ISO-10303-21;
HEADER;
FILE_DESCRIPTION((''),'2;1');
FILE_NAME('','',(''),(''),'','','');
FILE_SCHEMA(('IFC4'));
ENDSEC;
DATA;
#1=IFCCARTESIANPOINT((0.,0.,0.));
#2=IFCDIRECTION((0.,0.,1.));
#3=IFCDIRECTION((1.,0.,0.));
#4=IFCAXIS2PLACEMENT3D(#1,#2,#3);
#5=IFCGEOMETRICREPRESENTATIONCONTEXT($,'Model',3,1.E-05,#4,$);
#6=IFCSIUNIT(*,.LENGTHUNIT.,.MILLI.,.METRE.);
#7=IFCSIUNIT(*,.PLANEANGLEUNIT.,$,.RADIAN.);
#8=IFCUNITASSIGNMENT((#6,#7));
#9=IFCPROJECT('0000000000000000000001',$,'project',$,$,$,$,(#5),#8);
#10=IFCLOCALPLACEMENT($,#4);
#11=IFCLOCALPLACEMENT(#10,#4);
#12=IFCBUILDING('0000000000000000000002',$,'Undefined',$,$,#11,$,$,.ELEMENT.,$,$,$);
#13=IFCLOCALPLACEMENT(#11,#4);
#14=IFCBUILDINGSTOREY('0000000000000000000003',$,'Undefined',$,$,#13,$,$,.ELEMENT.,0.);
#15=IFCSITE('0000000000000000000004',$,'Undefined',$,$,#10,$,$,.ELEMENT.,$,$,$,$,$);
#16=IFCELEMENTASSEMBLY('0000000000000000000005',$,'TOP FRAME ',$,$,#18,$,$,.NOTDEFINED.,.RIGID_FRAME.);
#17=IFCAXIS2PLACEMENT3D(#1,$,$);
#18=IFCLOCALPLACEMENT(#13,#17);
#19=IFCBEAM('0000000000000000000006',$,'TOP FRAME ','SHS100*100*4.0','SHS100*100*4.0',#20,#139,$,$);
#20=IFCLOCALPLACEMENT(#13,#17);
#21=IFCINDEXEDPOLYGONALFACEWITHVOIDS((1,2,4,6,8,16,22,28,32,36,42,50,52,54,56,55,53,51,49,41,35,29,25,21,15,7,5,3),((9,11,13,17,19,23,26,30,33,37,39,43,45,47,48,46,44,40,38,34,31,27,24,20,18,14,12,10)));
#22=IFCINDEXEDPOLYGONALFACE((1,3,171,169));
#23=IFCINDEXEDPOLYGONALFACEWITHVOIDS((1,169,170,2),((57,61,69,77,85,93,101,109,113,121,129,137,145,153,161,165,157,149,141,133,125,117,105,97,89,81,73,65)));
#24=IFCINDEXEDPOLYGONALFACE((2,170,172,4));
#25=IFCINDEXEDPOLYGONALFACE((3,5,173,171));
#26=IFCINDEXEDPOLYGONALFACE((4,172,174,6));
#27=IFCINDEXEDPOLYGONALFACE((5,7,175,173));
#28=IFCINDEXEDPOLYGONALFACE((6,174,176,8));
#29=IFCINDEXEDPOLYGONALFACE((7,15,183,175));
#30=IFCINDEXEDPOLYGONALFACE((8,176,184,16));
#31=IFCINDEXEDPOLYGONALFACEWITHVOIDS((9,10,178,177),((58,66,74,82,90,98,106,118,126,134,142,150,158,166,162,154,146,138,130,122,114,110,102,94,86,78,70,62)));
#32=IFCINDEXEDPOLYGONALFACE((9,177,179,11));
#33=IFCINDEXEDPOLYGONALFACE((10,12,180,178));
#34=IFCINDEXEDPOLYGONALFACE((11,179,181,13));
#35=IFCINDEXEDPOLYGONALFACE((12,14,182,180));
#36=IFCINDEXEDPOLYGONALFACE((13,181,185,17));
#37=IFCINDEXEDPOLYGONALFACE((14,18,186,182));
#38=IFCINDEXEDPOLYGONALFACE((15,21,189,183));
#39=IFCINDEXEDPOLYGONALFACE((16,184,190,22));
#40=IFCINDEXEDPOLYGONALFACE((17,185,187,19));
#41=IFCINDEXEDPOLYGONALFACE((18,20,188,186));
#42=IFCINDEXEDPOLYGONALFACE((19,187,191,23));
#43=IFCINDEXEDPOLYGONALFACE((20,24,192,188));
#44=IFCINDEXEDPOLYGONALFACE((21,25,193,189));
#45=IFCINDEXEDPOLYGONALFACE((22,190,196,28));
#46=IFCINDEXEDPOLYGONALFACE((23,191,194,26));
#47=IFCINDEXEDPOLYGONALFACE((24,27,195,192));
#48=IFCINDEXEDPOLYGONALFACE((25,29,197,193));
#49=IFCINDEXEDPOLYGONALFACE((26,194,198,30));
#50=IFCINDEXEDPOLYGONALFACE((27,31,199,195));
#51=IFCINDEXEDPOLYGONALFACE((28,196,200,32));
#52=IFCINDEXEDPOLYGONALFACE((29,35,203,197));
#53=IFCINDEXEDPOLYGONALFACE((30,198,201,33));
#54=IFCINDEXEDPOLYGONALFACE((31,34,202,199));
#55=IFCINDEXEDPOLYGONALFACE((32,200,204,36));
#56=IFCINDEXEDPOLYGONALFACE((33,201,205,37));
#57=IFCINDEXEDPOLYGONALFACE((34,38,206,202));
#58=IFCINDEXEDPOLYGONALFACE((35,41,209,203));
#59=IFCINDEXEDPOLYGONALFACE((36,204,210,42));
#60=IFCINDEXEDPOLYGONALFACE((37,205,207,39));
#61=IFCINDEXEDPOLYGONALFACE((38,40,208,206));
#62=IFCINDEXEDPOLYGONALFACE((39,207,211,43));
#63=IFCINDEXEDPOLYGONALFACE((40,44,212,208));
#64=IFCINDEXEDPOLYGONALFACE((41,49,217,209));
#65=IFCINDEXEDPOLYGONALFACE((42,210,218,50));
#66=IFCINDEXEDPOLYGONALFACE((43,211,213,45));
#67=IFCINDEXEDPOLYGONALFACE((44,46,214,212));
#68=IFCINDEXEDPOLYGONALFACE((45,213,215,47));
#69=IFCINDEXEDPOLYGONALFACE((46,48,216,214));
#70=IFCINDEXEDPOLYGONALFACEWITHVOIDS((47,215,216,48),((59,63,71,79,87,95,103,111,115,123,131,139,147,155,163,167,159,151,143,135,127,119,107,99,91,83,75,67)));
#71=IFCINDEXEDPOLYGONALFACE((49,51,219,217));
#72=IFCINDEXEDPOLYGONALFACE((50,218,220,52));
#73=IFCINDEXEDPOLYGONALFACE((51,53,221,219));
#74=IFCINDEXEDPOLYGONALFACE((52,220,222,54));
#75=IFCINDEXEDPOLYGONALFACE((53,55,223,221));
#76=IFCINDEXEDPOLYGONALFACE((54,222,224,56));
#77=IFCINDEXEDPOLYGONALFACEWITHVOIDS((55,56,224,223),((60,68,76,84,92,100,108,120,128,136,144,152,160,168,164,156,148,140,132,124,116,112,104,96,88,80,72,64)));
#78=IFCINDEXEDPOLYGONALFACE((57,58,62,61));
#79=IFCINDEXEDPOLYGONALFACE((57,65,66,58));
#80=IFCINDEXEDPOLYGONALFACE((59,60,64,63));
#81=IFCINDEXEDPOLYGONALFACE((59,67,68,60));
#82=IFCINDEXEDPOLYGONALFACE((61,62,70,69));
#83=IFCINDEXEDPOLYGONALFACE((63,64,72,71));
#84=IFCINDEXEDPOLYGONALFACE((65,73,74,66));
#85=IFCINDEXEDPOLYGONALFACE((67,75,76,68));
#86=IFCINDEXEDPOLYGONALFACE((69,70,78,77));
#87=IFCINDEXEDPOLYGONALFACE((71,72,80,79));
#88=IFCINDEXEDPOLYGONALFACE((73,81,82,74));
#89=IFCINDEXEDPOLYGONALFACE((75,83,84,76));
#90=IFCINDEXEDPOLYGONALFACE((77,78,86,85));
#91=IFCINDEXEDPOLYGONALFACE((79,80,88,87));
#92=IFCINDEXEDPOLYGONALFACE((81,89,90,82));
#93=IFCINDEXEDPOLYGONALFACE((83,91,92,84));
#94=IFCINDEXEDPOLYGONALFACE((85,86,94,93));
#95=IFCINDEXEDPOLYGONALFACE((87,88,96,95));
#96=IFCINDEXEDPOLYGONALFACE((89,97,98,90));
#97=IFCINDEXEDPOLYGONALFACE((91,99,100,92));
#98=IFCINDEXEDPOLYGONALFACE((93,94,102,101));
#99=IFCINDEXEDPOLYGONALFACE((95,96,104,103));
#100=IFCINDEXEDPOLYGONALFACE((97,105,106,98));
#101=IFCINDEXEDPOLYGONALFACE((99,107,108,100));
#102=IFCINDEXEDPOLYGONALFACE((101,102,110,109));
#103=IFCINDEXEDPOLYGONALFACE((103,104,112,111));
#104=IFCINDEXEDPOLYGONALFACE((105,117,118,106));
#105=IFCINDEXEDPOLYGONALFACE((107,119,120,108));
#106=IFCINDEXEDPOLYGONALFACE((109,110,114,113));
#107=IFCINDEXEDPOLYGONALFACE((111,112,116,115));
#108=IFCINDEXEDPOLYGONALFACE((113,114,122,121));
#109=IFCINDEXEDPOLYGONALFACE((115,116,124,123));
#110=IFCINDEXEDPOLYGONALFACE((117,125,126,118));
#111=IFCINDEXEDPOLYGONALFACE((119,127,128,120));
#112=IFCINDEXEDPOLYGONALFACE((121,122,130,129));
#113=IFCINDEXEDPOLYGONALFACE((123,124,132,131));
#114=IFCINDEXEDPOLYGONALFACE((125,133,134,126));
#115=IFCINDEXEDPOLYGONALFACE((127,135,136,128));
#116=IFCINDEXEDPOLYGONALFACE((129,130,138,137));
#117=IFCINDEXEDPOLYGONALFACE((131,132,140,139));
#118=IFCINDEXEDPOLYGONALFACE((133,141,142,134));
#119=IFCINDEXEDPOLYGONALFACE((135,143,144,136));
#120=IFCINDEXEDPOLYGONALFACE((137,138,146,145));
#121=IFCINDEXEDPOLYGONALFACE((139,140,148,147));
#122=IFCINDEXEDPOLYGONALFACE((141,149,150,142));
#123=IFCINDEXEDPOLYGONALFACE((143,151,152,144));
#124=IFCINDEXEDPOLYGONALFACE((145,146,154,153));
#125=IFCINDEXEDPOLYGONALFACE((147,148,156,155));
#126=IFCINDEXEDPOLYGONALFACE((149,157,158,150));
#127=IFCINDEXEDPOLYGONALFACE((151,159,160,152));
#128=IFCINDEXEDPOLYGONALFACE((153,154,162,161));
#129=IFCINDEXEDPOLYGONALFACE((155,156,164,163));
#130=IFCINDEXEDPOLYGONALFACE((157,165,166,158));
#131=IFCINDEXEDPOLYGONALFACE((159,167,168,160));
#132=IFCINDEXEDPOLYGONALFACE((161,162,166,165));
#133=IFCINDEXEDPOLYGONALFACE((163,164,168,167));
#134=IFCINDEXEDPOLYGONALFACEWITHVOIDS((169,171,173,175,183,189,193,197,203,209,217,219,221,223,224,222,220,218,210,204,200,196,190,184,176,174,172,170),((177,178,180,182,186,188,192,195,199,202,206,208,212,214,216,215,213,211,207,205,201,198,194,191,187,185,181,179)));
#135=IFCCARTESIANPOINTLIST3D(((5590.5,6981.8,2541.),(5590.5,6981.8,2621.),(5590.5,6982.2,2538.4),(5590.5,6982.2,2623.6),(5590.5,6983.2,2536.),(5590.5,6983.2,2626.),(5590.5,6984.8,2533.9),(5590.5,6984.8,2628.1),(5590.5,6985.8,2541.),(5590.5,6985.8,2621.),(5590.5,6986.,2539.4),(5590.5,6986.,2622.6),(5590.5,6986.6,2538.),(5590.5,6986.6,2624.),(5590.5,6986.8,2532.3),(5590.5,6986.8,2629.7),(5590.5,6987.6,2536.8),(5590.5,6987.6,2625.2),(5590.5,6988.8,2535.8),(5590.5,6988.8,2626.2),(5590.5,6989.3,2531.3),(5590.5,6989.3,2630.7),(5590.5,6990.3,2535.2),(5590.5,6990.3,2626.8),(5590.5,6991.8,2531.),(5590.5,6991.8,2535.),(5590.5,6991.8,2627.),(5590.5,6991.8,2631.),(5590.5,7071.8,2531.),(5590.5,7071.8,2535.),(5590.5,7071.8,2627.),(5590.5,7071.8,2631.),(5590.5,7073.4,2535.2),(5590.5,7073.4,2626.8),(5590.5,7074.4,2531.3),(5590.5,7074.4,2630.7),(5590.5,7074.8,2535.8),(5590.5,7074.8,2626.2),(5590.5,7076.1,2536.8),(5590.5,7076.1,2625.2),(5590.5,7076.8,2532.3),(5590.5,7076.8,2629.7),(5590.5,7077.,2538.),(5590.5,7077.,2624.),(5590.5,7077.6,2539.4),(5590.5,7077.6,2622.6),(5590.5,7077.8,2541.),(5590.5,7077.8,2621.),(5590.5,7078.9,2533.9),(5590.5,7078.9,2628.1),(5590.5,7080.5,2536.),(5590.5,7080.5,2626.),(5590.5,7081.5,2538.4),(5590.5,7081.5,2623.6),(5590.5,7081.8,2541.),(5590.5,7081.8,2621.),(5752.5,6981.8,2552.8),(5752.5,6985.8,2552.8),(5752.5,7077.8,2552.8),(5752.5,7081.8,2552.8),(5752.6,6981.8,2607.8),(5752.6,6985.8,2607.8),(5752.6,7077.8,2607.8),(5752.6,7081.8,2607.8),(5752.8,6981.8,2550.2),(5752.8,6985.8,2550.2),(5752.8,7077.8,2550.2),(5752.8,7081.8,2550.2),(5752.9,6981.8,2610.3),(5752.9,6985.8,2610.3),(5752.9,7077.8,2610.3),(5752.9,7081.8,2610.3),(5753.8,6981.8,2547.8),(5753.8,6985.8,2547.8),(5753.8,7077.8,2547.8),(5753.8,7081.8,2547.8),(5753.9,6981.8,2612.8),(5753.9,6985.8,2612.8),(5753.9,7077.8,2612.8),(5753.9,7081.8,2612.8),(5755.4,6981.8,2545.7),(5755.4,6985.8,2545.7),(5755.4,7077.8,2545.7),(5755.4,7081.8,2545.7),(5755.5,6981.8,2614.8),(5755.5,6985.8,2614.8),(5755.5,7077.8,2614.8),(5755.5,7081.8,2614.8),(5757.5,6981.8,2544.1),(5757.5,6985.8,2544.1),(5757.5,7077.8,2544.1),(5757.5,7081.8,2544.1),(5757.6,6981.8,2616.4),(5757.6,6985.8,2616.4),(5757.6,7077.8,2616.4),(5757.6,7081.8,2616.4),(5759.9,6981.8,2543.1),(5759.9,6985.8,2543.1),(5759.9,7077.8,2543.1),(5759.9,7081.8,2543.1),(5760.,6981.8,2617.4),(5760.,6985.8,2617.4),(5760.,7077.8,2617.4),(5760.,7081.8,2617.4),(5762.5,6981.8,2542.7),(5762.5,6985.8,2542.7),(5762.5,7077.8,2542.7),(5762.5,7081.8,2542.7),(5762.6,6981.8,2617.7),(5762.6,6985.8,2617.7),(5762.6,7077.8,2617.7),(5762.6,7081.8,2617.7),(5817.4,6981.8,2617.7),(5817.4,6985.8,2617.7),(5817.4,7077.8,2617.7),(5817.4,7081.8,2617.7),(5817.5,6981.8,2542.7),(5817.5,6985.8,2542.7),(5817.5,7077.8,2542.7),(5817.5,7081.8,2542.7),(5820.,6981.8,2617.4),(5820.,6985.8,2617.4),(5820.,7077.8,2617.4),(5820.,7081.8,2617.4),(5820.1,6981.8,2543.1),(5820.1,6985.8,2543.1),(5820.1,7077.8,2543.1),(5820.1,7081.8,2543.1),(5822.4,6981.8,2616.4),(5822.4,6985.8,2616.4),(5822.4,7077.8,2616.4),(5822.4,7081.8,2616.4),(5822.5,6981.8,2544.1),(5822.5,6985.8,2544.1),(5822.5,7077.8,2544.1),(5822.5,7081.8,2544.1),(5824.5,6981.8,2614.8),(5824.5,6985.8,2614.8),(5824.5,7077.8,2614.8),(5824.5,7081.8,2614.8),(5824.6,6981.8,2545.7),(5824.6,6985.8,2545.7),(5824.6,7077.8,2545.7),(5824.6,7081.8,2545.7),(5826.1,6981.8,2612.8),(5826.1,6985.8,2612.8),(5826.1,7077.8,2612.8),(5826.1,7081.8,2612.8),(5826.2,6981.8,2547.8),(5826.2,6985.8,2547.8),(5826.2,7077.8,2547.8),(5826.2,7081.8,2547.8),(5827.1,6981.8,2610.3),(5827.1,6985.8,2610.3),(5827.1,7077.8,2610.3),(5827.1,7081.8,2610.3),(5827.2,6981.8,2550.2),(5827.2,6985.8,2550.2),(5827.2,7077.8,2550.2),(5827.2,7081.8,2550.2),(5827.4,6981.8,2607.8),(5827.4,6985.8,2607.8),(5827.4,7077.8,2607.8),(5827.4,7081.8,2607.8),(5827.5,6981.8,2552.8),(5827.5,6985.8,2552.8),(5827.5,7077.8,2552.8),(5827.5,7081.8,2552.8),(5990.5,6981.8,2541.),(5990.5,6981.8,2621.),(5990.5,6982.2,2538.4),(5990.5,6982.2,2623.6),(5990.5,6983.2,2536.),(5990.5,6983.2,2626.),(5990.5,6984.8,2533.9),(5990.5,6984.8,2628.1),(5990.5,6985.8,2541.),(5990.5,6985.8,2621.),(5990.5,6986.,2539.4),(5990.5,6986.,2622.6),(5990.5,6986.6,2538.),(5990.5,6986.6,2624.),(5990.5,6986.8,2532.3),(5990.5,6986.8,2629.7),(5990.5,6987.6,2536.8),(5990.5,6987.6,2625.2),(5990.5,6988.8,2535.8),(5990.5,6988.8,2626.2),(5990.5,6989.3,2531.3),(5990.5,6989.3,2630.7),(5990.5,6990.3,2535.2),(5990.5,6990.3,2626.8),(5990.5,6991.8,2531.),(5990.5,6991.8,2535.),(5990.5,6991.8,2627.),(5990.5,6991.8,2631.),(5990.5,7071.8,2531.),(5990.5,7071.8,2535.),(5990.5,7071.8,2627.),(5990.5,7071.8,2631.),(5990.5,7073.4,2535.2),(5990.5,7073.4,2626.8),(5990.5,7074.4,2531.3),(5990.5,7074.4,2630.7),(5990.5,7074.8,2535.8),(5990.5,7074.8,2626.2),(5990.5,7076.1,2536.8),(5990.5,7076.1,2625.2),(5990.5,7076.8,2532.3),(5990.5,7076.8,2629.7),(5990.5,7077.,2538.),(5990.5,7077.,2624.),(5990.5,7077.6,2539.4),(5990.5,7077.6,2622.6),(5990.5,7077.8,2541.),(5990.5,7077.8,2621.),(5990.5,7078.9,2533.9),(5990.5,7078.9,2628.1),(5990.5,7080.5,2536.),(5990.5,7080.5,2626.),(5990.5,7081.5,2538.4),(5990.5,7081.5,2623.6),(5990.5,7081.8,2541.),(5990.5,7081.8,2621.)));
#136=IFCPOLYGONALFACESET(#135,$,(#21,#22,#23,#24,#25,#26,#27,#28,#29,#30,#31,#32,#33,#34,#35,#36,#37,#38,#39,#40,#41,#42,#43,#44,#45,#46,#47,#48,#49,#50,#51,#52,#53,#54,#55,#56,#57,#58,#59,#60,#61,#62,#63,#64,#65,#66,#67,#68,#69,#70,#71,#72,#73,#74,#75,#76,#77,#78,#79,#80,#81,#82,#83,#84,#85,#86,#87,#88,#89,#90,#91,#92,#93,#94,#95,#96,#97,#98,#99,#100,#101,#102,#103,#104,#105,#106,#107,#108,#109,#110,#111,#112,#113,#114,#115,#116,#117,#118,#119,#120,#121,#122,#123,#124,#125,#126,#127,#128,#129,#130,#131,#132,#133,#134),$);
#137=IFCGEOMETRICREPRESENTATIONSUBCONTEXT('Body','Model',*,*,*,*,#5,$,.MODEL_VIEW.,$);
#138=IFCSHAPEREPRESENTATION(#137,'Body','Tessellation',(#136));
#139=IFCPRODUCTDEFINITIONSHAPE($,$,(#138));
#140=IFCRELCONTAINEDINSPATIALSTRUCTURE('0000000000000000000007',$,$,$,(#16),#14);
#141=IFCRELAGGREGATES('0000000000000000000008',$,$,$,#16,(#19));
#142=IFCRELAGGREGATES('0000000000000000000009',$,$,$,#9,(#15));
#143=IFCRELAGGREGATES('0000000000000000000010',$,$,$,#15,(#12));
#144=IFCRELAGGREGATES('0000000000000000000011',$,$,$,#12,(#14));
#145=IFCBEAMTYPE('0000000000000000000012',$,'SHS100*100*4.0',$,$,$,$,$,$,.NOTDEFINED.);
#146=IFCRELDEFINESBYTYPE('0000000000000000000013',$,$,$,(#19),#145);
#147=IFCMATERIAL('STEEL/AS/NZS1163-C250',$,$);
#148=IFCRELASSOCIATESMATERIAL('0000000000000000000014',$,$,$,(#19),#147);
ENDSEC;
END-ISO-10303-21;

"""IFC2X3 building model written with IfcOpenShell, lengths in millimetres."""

from ifc_helpers import new_model, si_unit, frame, frame_2d, origin_with_axes, origin_2d_with_axis, place, context, subcontext, project, spatial, polyline, circle_curve, parameter, trimmed, segment, composite_curve, hollow_rectangle, outline, extrude, boolean, material, type_object, element, aggregate, save


model = new_model("IFC2X3")

# Units and contexts
model_context = context("Model", 3, precision=1e-05, world=origin_with_axes())
body_context = subcontext(model_context, "Body", "Model", "MODEL_VIEW")
ifc_project = project(units=[si_unit("LENGTHUNIT", "METRE", prefix="MILLI"), si_unit("PLANEANGLEUNIT", "RADIAN")], contexts=[model_context])

# Site, building, storey
site_placement = place(None, origin_with_axes())
site = spatial("IfcSite", under=ifc_project, at=site_placement, Name="Undefined", CompositionType="ELEMENT")
building_placement = place(site_placement, origin_with_axes())
building = spatial("IfcBuilding", under=site, at=building_placement, Name="Undefined", CompositionType="ELEMENT")
storey_placement = place(building_placement, origin_with_axes())
storey = spatial("IfcBuildingStorey", under=building, at=storey_placement, Name="Undefined", CompositionType="ELEMENT", Elevation=0.0)

# Element assembly
ifc_material_1 = material(Name="STEEL/AS/NZS1163-C250")
assembly_1_placement = place(storey_placement, origin_with_axes())
assembly_1 = element("IfcElementAssembly", 1, at=assembly_1_placement, inside=storey, Name="TOP FRAME ", AssemblyPlace="NOTDEFINED", PredefinedType="RIGID_FRAME")

# Beam
beam_type_1 = type_object("IfcBeamType", Name="SHS100*100*4.0", PredefinedType="NOTDEFINED")
beam_1_placement = place(assembly_1_placement, frame((5990.5, 7031.8, 2581.0), z_axis=(0.0, 0.0, 1.0), x_axis=(-1.0, 0.0, 0.0)))
beam_1 = element("IfcBeam", 2, at=beam_1_placement, type_object=beam_type_1, material=ifc_material_1, Name="TOP FRAME ", Description="SHS100*100*4.0", ObjectType="SHS100*100*4.0", context=body_context, shape_type="CSG", body=[
    boolean("DIFFERENCE", extrude(hollow_rectangle(XDim=100.0, YDim=100.0, WallThickness=4.0, InnerFilletRadius=6.0, OuterFilletRadius=10.0, at=origin_2d_with_axis()), frame((400.0, 0.0, 0.0), z_axis=(-1.0, 0.0, 0.0), x_axis=(0.0, -1.0, 0.0)), (0.0, 0.0, 1.0), 400.0), extrude(outline(composite_curve([segment(trimmed(circle_curve(frame_2d((10.0, 10.0), x_axis=(-0.999999, -0.001138)), 10.0), [parameter(0.0)], [parameter(1.569658)], True, "PARAMETER"), True, "CONTINUOUS"), segment(polyline([(10.0, 0.0), (64.8, 0.0)]), True, "CONTINUOUS"), segment(trimmed(circle_curve(frame_2d((64.8, 10.0), x_axis=(0.0, -1.0)), 10.0), [parameter(0.0)], [parameter(1.569658)], True, "PARAMETER"), True, "CONTINUOUS"), segment(polyline([(74.8, 10.0), (74.9, 65.0)]), True, "CONTINUOUS"), segment(trimmed(circle_curve(frame_2d((64.9, 65.0), x_axis=(0.999999, -0.001138)), 10.0), [parameter(0.0)], [parameter(1.571934)], True, "PARAMETER"), True, "CONTINUOUS"), segment(polyline([(64.9, 75.0), (9.9, 75.0)]), True, "CONTINUOUS"), segment(trimmed(circle_curve(frame_2d((9.9, 65.0), x_axis=(0.0, 1.0)), 10.0), [parameter(0.0)], [parameter(1.571934)], True, "PARAMETER"), True, "CONTINUOUS"), segment(polyline([(-0.1, 65.0), (0.0, 10.0)]), True, "CONTINUOUS")], self_intersect=True)), frame((237.9, 53.0, 36.7), z_axis=(-0.000004, -1.0, 0.0), x_axis=(-1.0, 0.000004, 0.0)), (0.0, 0.0, 1.0), 106.0)),
])
aggregate(assembly_1, [beam_1])

save(model, "model.ifc")
